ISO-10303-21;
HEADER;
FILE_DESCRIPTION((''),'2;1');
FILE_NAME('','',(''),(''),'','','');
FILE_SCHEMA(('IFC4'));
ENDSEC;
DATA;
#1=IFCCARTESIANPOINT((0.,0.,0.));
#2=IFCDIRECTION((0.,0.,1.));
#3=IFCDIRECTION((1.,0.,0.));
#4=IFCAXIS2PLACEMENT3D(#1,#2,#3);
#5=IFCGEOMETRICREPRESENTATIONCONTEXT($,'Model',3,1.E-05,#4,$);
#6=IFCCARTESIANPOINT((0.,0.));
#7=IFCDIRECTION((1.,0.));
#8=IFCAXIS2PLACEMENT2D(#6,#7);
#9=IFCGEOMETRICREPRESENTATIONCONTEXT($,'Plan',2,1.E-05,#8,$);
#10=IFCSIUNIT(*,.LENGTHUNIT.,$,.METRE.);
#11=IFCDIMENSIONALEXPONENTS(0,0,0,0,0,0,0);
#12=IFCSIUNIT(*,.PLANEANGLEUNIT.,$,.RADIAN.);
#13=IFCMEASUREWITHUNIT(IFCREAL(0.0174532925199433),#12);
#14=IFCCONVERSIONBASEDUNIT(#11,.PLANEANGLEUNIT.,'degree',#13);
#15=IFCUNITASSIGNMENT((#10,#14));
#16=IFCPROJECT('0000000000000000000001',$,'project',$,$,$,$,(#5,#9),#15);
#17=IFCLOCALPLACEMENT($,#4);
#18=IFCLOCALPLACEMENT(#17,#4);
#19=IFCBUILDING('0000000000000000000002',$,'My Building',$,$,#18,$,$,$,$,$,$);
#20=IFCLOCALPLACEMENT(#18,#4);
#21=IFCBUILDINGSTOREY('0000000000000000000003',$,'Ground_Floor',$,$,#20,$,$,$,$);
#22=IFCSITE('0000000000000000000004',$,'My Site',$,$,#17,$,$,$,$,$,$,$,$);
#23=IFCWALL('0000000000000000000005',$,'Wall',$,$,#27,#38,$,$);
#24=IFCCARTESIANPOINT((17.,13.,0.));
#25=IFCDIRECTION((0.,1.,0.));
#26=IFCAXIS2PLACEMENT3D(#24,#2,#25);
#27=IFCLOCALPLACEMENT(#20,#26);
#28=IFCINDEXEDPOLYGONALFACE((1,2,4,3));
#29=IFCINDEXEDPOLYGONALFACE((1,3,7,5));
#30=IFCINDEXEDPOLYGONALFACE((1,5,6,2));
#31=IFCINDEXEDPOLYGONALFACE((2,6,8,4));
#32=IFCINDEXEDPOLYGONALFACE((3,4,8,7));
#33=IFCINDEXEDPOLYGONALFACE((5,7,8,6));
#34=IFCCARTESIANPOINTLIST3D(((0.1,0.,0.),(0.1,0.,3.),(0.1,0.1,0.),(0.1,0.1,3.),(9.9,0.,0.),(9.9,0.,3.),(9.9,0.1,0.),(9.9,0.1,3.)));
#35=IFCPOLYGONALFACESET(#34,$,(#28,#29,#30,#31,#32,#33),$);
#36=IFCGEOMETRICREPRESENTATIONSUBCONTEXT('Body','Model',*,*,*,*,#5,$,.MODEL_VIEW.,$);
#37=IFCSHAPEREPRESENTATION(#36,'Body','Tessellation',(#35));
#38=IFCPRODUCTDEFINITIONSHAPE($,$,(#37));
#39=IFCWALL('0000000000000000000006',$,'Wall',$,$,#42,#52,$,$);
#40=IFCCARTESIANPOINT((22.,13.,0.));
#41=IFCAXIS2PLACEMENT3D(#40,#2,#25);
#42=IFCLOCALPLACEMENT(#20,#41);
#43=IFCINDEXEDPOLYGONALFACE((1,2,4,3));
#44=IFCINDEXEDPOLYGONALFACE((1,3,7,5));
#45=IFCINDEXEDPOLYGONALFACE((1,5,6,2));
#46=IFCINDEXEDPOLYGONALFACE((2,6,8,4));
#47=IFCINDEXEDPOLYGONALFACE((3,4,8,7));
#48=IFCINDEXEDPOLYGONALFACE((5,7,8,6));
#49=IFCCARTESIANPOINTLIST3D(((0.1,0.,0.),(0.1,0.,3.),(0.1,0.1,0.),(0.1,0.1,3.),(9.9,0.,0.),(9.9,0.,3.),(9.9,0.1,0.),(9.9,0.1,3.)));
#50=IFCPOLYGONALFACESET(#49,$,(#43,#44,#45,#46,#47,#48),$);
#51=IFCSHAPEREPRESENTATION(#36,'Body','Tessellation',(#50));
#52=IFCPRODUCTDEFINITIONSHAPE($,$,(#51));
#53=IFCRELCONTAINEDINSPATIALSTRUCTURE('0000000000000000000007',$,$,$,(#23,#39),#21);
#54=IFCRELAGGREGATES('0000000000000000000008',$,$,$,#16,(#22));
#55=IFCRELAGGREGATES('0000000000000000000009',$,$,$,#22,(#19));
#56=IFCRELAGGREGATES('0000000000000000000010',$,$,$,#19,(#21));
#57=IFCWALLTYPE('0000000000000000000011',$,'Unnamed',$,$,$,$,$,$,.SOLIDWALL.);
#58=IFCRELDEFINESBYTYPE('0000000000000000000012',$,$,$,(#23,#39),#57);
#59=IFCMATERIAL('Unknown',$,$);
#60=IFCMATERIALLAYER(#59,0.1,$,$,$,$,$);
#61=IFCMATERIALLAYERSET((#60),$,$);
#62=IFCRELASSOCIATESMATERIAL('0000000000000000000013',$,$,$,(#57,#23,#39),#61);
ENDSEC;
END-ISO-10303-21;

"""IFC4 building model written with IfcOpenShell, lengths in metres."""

from ifc_helpers import new_model, entity, si_unit, converted_unit, frame, origin_with_axes, origin_2d_with_axis, place, context, subcontext, project, spatial, line, indexed_curve, outline, extrude, material, layer, layer_set, layer_usage, type_object, element, save


model = new_model("IFC4")

# Units and contexts
model_context = context("Model", 3, precision=1e-05, world=origin_with_axes())
plan_context = context("Plan", 2, precision=1e-05, world=origin_2d_with_axis())
body_context_1 = subcontext(model_context, "Body", "Model", "MODEL_VIEW")
ifc_project = project(units=[si_unit("LENGTHUNIT", "METRE"), converted_unit("PLANEANGLEUNIT", "degree", entity("IfcReal", 0.0174532925199433), si_unit("PLANEANGLEUNIT", "RADIAN"), dimensions=[0, 0, 0, 0, 0, 0, 0])], contexts=[model_context, plan_context])

# Site, building, storey
site_placement = place(None, origin_with_axes())
site = spatial("IfcSite", under=ifc_project, at=site_placement, Name="My Site")
building_placement = place(site_placement, origin_with_axes())
building = spatial("IfcBuilding", under=site, at=building_placement, Name="My Building")
storey_placement = place(building_placement, origin_with_axes())
storey = spatial("IfcBuildingStorey", under=building, at=storey_placement, Name="Ground_Floor")

# Shared definitions
ifc_material = material(Name="Unknown")
ifc_layer = layer(ifc_material, 0.1)
ifc_layer_set = layer_set([ifc_layer])
wall_type = type_object("IfcWallType", Name="Unnamed", PredefinedType="SOLIDWALL", material=ifc_layer_set)

# Walls
ifc_layer_usage_1 = layer_usage(ifc_layer_set, "AXIS2", "POSITIVE", 0.0)
wall_1_placement = place(storey_placement, frame((17.0, 13.0, 0.0), z_axis=(0.0, 0.0, 1.0), x_axis=(0.0, 1.0, 0.0)))
element("IfcWall", 1, at=wall_1_placement, inside=storey, type_object=wall_type, material=ifc_layer_usage_1, Name="Wall", context=body_context_1, shape_type="SweptSolid", body=[
    extrude(outline(indexed_curve([(0.1, 0.0), (0.1, 0.1), (9.9, 0.1), (9.9, 0.0)], segments=[line(1, 2, 3, 4, 1)])), origin_with_axes(), (0.0, 0.0, 1.0), 3.0),
])
ifc_layer_usage_2 = layer_usage(ifc_layer_set, "AXIS2", "POSITIVE", 0.0)
wall_2_placement = place(storey_placement, frame((22.0, 13.0, 0.0), z_axis=(0.0, 0.0, 1.0), x_axis=(0.0, 1.0, 0.0)))
element("IfcWall", 2, at=wall_2_placement, inside=storey, type_object=wall_type, material=ifc_layer_usage_2, Name="Wall", context=body_context_1, shape_type="SweptSolid", body=[
    extrude(outline(indexed_curve([(0.1, 0.0), (0.1, 0.1), (9.9, 0.1), (9.9, 0.0)], segments=[line(1, 2, 3, 4, 1)])), origin_with_axes(), (0.0, 0.0, 1.0), 3.0),
])

save(model, "model.ifc")
